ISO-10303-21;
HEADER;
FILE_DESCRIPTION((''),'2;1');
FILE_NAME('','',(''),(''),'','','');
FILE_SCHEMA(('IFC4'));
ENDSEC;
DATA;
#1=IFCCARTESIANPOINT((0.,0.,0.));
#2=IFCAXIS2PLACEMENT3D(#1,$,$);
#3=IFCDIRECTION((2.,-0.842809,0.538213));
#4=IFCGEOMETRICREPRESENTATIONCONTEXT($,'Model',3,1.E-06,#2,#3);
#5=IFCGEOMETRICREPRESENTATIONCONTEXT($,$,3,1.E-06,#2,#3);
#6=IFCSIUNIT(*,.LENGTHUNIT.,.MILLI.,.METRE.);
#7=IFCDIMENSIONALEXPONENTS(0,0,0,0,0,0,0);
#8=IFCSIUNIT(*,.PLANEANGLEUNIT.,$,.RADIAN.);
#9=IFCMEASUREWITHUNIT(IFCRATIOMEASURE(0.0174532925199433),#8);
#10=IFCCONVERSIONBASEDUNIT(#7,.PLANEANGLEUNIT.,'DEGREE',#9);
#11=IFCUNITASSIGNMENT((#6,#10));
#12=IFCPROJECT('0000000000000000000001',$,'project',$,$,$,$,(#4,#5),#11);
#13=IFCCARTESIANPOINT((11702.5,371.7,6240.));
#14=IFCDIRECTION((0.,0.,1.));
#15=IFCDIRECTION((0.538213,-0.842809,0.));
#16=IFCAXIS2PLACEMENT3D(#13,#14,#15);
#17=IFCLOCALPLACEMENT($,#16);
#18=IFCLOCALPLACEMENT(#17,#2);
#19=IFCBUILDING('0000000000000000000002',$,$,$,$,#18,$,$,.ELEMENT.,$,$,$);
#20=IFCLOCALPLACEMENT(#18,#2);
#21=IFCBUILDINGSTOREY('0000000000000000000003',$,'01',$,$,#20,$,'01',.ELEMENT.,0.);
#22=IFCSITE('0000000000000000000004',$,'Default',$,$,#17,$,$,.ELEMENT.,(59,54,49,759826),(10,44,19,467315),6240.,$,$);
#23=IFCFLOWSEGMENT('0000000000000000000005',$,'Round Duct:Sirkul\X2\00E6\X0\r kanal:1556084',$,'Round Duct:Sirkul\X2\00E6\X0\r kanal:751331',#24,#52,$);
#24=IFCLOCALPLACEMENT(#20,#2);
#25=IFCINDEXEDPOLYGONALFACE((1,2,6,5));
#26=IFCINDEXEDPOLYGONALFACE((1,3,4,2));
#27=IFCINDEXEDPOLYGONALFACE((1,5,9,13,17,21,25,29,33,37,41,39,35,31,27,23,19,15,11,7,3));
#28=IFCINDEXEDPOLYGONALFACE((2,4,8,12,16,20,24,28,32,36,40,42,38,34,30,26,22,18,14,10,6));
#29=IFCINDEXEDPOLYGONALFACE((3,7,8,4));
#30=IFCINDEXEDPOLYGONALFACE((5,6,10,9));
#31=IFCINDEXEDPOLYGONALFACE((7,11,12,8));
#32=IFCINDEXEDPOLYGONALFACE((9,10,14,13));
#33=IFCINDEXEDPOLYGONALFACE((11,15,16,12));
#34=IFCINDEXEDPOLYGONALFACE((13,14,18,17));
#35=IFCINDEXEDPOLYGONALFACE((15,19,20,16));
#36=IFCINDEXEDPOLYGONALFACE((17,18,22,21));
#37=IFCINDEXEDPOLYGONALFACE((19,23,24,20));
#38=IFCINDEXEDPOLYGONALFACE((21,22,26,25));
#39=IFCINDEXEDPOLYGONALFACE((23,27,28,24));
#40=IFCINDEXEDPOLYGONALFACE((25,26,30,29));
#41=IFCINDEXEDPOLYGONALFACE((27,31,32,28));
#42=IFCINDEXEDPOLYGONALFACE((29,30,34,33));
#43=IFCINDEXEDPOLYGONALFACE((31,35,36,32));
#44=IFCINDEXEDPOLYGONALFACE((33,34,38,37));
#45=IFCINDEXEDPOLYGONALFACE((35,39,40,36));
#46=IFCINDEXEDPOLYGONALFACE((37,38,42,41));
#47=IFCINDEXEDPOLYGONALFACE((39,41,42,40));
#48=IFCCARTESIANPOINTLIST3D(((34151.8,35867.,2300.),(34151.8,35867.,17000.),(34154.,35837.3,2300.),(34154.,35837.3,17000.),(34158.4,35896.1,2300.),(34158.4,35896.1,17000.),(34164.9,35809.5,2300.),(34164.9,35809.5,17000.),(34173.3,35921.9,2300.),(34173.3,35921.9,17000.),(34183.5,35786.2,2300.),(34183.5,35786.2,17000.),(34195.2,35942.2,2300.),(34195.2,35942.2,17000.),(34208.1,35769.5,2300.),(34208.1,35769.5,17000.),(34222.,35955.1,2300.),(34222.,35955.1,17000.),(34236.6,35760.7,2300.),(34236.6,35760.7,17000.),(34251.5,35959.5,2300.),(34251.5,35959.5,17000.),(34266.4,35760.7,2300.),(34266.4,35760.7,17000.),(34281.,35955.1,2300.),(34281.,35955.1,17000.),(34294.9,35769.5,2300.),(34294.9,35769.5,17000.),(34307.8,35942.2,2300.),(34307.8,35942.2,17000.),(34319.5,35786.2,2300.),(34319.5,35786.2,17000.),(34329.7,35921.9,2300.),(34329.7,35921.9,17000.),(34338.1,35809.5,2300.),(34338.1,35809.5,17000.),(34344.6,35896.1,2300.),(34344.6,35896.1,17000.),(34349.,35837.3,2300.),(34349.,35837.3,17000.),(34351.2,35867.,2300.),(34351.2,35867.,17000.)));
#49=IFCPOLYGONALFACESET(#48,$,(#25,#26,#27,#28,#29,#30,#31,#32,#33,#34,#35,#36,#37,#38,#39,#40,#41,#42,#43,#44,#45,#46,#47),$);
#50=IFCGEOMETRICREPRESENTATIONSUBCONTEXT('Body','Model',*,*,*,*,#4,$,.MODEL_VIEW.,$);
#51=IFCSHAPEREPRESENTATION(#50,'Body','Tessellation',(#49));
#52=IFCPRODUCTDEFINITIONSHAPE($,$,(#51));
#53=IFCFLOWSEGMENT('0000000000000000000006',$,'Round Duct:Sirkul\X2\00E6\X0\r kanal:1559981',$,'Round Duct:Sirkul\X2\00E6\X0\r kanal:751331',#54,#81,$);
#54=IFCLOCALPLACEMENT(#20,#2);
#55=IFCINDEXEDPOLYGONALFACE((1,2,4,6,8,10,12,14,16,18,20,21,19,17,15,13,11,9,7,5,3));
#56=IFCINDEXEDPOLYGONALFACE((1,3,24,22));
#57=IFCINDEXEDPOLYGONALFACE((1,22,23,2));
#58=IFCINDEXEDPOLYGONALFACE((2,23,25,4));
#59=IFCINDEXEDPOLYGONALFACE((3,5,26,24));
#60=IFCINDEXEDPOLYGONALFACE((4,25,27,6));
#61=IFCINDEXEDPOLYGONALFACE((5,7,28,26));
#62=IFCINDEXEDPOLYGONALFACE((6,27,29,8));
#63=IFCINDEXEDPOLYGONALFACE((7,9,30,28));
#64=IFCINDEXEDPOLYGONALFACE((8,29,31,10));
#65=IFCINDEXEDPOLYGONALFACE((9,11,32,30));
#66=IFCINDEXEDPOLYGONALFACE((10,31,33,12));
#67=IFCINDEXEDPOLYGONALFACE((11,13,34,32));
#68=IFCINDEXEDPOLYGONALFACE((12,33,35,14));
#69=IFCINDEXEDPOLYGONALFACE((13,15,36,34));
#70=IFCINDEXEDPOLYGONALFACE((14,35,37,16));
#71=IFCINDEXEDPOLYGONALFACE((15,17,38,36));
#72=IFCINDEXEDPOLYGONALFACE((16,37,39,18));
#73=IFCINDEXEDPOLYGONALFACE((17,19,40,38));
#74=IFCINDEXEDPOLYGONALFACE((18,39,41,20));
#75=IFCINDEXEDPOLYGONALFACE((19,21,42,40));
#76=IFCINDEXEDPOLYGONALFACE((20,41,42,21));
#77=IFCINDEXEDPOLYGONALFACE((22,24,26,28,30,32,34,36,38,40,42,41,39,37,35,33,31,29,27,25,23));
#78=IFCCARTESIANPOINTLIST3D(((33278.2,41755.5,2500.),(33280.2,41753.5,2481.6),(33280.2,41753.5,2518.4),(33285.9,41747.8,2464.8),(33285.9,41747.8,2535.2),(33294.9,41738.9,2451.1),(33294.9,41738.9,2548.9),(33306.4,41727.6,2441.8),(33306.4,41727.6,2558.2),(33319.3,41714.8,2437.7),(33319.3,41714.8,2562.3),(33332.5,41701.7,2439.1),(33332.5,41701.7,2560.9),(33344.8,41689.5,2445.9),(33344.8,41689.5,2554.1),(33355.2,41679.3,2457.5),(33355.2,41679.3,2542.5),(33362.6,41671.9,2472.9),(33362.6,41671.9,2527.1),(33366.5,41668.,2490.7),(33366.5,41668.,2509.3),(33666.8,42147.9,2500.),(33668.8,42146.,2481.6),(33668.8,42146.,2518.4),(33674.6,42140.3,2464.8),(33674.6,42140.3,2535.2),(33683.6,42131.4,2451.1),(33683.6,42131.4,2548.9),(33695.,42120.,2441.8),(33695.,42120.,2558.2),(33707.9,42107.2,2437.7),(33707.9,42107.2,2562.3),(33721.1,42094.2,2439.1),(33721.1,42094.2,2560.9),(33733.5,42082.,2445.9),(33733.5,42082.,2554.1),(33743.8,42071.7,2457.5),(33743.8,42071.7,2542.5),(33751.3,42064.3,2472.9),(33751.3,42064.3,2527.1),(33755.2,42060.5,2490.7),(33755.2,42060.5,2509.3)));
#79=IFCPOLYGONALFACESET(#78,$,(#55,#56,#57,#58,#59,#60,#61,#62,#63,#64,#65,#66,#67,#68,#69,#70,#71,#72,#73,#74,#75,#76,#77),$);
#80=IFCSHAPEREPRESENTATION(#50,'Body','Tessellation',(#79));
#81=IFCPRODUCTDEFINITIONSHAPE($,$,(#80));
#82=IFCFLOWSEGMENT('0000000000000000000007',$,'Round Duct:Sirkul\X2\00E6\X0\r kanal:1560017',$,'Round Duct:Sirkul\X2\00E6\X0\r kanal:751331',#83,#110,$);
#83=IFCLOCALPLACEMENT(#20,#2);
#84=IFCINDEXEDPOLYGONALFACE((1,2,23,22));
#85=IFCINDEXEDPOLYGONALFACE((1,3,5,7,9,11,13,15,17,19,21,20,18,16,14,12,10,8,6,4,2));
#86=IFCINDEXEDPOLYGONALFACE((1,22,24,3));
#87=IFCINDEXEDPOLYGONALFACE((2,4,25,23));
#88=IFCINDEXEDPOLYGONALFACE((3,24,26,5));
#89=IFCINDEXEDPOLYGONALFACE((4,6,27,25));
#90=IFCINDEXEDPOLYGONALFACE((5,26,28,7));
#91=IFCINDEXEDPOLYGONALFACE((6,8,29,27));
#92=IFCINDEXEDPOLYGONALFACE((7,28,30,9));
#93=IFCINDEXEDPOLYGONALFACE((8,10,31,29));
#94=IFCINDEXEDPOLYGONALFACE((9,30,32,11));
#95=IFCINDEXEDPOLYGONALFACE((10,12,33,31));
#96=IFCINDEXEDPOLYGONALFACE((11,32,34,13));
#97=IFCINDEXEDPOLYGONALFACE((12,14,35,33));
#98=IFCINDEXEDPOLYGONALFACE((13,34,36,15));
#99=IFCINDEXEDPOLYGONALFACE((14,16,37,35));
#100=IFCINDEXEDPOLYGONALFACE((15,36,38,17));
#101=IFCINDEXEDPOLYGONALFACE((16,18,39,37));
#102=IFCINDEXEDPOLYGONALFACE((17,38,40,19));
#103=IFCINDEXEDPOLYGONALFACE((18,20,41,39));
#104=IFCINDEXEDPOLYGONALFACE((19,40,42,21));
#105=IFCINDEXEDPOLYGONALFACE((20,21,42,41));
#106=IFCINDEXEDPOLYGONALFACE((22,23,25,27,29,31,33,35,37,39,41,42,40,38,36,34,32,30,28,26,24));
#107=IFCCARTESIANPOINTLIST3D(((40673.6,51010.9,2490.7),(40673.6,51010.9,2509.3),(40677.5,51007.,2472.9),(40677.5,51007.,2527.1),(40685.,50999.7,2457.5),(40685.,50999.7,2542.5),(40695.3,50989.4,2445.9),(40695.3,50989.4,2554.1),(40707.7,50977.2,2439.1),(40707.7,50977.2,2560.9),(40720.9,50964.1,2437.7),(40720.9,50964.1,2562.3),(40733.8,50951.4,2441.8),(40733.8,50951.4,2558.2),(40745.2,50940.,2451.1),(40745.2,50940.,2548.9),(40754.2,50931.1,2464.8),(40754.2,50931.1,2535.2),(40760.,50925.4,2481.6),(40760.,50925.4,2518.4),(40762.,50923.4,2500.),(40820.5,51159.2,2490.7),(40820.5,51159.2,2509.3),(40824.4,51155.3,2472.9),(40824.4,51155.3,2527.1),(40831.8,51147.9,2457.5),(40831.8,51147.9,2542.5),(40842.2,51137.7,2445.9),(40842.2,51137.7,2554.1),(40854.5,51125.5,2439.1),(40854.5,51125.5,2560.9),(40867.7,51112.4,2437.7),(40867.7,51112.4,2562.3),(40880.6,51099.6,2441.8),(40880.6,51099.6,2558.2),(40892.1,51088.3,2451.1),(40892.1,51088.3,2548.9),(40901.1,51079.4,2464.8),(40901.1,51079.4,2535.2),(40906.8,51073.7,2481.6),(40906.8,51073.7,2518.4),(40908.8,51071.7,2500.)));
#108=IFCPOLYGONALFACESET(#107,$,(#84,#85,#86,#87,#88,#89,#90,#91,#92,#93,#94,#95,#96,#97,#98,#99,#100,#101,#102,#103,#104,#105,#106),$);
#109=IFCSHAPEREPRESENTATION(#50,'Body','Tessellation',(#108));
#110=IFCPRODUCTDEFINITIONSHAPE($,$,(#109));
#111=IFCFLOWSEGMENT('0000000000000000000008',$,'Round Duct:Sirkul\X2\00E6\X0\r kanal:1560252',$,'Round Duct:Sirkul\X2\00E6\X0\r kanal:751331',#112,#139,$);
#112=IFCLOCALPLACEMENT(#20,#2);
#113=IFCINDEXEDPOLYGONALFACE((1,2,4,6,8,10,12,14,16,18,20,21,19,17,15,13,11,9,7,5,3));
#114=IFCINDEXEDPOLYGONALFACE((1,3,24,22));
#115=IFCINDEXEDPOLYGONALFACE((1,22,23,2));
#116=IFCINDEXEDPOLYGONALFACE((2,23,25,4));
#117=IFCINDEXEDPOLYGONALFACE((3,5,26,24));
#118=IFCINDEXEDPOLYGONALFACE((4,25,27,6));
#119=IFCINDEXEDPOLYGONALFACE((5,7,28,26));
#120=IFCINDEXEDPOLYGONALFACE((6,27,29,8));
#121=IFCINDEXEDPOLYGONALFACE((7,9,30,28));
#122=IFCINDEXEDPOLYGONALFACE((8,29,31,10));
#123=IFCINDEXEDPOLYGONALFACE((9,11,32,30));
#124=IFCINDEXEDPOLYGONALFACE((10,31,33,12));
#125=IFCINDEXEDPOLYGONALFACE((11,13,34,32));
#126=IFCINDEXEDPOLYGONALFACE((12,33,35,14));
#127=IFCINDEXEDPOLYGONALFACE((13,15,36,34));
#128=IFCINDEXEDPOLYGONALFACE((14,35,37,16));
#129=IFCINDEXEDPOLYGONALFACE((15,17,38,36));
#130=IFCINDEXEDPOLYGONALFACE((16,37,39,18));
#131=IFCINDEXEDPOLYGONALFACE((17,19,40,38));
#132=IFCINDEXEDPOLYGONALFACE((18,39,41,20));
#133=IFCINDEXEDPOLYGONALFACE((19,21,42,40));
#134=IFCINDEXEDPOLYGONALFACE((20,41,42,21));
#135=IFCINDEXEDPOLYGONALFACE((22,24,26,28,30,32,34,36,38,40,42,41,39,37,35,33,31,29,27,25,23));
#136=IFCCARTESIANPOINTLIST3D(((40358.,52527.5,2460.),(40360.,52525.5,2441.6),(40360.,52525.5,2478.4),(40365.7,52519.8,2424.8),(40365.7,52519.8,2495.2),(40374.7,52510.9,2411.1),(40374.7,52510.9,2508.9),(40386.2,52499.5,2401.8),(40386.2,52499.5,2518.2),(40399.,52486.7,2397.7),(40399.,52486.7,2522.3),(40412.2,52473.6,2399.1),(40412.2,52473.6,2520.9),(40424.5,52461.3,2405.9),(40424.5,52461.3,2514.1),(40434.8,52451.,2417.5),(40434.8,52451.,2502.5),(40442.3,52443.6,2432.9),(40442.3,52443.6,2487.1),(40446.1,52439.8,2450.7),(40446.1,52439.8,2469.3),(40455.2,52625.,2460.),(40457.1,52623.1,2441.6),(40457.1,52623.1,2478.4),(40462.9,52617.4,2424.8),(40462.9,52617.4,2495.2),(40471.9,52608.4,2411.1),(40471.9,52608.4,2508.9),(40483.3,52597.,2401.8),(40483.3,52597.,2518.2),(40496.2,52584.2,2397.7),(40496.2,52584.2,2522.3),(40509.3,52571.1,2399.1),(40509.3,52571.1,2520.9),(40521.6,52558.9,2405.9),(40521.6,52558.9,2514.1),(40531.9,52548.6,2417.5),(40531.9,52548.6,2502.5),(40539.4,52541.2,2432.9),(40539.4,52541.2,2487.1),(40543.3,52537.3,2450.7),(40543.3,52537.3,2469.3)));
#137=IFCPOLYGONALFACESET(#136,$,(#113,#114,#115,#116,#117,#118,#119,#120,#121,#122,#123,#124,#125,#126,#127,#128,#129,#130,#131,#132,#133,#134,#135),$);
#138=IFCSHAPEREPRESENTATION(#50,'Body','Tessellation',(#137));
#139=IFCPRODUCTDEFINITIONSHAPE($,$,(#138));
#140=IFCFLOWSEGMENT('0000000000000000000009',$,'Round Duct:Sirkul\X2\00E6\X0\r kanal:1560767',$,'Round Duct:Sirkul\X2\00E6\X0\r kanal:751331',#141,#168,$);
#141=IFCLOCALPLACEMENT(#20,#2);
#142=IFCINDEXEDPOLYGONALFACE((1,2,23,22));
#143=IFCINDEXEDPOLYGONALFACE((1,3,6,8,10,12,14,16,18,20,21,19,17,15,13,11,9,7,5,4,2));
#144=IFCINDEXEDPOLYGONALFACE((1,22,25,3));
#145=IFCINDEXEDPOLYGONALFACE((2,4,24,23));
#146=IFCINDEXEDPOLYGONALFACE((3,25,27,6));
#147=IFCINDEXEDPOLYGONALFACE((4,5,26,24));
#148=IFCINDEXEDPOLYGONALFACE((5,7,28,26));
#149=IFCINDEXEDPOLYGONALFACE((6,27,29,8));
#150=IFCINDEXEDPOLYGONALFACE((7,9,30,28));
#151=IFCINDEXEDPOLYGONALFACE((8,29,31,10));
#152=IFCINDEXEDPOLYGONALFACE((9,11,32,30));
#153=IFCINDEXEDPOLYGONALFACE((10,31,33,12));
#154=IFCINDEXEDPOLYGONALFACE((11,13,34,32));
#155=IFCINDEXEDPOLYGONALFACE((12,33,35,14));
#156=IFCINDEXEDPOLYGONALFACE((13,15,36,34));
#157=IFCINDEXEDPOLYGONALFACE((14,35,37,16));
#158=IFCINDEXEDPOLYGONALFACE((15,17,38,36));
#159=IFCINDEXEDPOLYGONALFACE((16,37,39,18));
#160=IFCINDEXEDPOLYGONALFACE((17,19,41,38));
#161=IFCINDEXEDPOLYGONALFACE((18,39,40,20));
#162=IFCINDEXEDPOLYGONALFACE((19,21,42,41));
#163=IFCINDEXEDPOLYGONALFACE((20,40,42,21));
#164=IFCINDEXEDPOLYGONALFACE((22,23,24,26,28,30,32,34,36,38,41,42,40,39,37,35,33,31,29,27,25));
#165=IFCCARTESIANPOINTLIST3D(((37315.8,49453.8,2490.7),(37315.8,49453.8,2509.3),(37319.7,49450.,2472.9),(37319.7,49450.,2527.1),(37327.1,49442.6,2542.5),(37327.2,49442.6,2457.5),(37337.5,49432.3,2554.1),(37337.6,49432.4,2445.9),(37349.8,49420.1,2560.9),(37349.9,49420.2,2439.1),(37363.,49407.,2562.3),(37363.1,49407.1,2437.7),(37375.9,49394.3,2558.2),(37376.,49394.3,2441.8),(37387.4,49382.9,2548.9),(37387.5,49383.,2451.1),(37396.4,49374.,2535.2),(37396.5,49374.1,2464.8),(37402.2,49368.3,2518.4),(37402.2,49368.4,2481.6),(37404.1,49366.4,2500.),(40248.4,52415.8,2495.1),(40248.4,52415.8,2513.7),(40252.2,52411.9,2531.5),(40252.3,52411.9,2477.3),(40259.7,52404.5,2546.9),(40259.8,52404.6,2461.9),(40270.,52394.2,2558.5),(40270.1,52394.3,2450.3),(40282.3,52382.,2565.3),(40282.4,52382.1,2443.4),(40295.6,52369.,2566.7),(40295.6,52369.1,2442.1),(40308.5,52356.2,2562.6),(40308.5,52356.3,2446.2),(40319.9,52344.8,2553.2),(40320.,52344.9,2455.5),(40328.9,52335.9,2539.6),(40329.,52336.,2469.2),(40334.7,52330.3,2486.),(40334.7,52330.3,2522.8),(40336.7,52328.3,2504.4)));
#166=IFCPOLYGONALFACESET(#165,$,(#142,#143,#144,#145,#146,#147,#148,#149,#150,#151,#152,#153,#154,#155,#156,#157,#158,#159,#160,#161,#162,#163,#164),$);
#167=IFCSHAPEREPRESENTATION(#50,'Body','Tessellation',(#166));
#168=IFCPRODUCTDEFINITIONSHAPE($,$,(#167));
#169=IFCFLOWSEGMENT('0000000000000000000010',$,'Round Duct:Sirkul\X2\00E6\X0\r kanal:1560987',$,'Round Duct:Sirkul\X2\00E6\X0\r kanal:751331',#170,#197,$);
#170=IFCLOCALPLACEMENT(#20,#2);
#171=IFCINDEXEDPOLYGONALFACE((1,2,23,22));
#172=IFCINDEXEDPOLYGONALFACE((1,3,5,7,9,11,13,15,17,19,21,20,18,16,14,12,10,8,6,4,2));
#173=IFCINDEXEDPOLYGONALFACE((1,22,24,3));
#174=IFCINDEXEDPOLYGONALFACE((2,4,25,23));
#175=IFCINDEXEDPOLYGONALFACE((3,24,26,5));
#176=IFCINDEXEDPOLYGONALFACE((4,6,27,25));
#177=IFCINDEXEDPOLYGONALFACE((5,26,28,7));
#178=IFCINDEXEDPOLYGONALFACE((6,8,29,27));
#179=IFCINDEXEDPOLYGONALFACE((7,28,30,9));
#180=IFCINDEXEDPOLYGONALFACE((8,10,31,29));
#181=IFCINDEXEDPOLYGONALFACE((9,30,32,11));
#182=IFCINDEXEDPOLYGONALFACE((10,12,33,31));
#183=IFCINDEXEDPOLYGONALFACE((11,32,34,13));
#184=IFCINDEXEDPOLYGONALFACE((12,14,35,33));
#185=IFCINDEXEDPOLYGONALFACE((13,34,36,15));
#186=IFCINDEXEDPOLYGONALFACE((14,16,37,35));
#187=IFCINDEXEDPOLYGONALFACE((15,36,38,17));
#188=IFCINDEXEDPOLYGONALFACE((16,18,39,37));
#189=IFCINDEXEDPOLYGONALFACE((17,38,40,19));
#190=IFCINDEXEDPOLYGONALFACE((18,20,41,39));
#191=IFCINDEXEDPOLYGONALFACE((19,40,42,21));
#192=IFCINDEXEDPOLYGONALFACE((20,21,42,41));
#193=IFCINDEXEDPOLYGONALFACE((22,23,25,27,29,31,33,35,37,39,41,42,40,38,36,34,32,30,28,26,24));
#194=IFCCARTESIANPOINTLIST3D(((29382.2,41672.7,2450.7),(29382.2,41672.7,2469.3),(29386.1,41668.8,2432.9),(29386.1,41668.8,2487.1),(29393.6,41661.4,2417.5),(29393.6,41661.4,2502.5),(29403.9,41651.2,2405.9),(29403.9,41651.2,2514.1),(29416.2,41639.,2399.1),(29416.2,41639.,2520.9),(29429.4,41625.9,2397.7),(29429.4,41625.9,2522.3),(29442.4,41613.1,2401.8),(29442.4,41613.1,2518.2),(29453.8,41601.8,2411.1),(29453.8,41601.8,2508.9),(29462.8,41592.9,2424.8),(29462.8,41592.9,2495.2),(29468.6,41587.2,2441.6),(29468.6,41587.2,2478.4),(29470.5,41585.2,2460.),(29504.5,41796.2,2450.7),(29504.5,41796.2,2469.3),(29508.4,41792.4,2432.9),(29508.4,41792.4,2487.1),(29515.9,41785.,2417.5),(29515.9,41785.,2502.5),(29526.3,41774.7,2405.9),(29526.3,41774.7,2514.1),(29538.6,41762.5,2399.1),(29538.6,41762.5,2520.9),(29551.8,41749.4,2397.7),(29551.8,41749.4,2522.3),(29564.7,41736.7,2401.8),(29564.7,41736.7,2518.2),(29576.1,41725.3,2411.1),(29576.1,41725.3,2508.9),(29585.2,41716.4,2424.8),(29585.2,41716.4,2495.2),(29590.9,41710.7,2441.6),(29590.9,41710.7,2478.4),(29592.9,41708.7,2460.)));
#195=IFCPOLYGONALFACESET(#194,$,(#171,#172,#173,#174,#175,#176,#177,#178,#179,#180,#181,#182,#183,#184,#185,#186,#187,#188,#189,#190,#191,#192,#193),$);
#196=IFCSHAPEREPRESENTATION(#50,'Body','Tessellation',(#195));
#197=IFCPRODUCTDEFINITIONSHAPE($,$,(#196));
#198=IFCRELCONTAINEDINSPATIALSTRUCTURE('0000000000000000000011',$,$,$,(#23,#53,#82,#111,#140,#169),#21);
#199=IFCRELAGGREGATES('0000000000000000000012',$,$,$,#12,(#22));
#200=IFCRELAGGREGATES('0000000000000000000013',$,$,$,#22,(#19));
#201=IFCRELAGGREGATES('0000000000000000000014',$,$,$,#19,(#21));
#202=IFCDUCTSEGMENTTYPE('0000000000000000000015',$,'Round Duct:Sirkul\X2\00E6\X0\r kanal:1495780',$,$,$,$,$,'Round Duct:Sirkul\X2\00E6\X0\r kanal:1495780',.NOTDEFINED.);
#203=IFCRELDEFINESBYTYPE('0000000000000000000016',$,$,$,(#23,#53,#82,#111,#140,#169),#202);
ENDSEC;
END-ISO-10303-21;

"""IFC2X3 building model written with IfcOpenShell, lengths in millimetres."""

from ifc_helpers import new_model, entity, si_unit, converted_unit, direction, frame, frame_2d, origin, origin_2d_with_axis, place, context, subcontext, project, spatial, circle, extrude, type_object, element, save


model = new_model("IFC2X3")

# Units and contexts
model_context = context("Model", 3, precision=1e-06, world=origin(), true_north=direction((2.0, -0.842809, 0.538213)))
context_of_model = context(None, 3, precision=1e-06, world=origin(), true_north=direction((2.0, -0.842809, 0.538213)))
body_context = subcontext(model_context, "Body", "Model", "MODEL_VIEW")
ifc_project = project(units=[si_unit("LENGTHUNIT", "METRE", prefix="MILLI"), converted_unit("PLANEANGLEUNIT", "DEGREE", entity("IfcRatioMeasure", 0.0174532925199433), si_unit("PLANEANGLEUNIT", "RADIAN"), dimensions=[0, 0, 0, 0, 0, 0, 0])], contexts=[model_context, context_of_model])

# Site, building, storey
site_placement = place(None, frame((11702.5, 371.7, 6240.0), z_axis=(0.0, 0.0, 1.0), x_axis=(0.538213, -0.842809, 0.0)))
site = spatial("IfcSite", under=ifc_project, at=site_placement, Name="Default", CompositionType="ELEMENT", RefLatitude=(59, 54, 49, 759826), RefLongitude=(10, 44, 19, 467315), RefElevation=6240.0)
building_placement = place(site_placement, origin())
building = spatial("IfcBuilding", under=site, at=building_placement, CompositionType="ELEMENT")
storey_placement = place(building_placement, origin())
storey = spatial("IfcBuildingStorey", under=building, at=storey_placement, Name="01", LongName="01", CompositionType="ELEMENT", Elevation=0.0)

# Flow segments
duct_segment_type = type_object("IfcDuctSegmentType", Name="Round Duct:Sirkulær kanal:1495780", ElementType="Round Duct:Sirkulær kanal:1495780", PredefinedType="NOTDEFINED")
flow_segment_1_placement = place(storey_placement, origin())
element("IfcFlowSegment", 1, at=flow_segment_1_placement, inside=storey, type_object=duct_segment_type, Name="Round Duct:Sirkulær kanal:1556084", ObjectType="Round Duct:Sirkulær kanal:751331", context=body_context, shape_type="SweptSolid", body=[
    extrude(circle(Radius=100.0, at=origin_2d_with_axis()), frame((34251.5, 35859.5, 2300.0), z_axis=(0.0, 0.0, 1.0), x_axis=(0.0, 1.0, 0.0)), (0.0, 0.0, 1.0), 14700.0),
])
flow_segment_2_placement = place(storey_placement, origin())
element("IfcFlowSegment", 2, at=flow_segment_2_placement, inside=storey, type_object=duct_segment_type, Name="Round Duct:Sirkulær kanal:1559981", ObjectType="Round Duct:Sirkulær kanal:751331", context=body_context, shape_type="SweptSolid", body=[
    extrude(circle(Radius=62.5, at=origin_2d_with_axis()), frame((33322.6, 41711.5, 2500.0), z_axis=(0.703643, 0.710554, 0.0), x_axis=(-0.710554, 0.703643, 0.0)), (0.0, 0.0, 1.0), 552.3),
])
flow_segment_3_placement = place(storey_placement, origin())
element("IfcFlowSegment", 3, at=flow_segment_3_placement, inside=storey, type_object=duct_segment_type, Name="Round Duct:Sirkulær kanal:1560017", ObjectType="Round Duct:Sirkulær kanal:751331", context=body_context, shape_type="SweptSolid", body=[
    extrude(circle(Radius=62.5, at=origin_2d_with_axis()), frame((40717.6, 50967.4, 2500.0), z_axis=(0.703643, 0.710554, 0.0), x_axis=(0.710554, -0.703643, 0.0)), (0.0, 0.0, 1.0), 208.7),
])
flow_segment_4_placement = place(storey_placement, origin())
element("IfcFlowSegment", 4, at=flow_segment_4_placement, inside=storey, type_object=duct_segment_type, Name="Round Duct:Sirkulær kanal:1560252", ObjectType="Round Duct:Sirkulær kanal:751331", context=body_context, shape_type="SweptSolid", body=[
    extrude(circle(Radius=62.5, at=origin_2d_with_axis()), frame((40402.3, 52483.4, 2460.0), z_axis=(0.705497, 0.708713, 0.0), x_axis=(-0.708713, 0.705497, 0.0)), (0.0, 0.0, 1.0), 137.7),
])
flow_segment_5_placement = place(storey_placement, origin())
element("IfcFlowSegment", 5, at=flow_segment_5_placement, inside=storey, type_object=duct_segment_type, Name="Round Duct:Sirkulær kanal:1560767", ObjectType="Round Duct:Sirkulær kanal:751331", context=body_context, shape_type="SweptSolid", body=[
    extrude(circle(Radius=62.5, at=frame_2d((0.0, 0.0), x_axis=(1.0, 0.0))), frame((37359.7, 49410.4, 2500.0), z_axis=(0.703572, 0.710623, 0.001051), x_axis=(0.710623, -0.703573, 0.0)), (0.0, 0.0, 1.0), 4168.1),
])
flow_segment_6_placement = place(storey_placement, origin())
element("IfcFlowSegment", 6, at=flow_segment_6_placement, inside=storey, type_object=duct_segment_type, Name="Round Duct:Sirkulær kanal:1560987", ObjectType="Round Duct:Sirkulær kanal:751331", context=body_context, shape_type="SweptSolid", body=[
    extrude(circle(Radius=62.5, at=origin_2d_with_axis()), frame((29426.1, 41629.2, 2460.0), z_axis=(0.703671, 0.710526, 0.0), x_axis=(0.710526, -0.703671, 0.0)), (0.0, 0.0, 1.0), 173.9),
])

save(model, "model.ifc")
